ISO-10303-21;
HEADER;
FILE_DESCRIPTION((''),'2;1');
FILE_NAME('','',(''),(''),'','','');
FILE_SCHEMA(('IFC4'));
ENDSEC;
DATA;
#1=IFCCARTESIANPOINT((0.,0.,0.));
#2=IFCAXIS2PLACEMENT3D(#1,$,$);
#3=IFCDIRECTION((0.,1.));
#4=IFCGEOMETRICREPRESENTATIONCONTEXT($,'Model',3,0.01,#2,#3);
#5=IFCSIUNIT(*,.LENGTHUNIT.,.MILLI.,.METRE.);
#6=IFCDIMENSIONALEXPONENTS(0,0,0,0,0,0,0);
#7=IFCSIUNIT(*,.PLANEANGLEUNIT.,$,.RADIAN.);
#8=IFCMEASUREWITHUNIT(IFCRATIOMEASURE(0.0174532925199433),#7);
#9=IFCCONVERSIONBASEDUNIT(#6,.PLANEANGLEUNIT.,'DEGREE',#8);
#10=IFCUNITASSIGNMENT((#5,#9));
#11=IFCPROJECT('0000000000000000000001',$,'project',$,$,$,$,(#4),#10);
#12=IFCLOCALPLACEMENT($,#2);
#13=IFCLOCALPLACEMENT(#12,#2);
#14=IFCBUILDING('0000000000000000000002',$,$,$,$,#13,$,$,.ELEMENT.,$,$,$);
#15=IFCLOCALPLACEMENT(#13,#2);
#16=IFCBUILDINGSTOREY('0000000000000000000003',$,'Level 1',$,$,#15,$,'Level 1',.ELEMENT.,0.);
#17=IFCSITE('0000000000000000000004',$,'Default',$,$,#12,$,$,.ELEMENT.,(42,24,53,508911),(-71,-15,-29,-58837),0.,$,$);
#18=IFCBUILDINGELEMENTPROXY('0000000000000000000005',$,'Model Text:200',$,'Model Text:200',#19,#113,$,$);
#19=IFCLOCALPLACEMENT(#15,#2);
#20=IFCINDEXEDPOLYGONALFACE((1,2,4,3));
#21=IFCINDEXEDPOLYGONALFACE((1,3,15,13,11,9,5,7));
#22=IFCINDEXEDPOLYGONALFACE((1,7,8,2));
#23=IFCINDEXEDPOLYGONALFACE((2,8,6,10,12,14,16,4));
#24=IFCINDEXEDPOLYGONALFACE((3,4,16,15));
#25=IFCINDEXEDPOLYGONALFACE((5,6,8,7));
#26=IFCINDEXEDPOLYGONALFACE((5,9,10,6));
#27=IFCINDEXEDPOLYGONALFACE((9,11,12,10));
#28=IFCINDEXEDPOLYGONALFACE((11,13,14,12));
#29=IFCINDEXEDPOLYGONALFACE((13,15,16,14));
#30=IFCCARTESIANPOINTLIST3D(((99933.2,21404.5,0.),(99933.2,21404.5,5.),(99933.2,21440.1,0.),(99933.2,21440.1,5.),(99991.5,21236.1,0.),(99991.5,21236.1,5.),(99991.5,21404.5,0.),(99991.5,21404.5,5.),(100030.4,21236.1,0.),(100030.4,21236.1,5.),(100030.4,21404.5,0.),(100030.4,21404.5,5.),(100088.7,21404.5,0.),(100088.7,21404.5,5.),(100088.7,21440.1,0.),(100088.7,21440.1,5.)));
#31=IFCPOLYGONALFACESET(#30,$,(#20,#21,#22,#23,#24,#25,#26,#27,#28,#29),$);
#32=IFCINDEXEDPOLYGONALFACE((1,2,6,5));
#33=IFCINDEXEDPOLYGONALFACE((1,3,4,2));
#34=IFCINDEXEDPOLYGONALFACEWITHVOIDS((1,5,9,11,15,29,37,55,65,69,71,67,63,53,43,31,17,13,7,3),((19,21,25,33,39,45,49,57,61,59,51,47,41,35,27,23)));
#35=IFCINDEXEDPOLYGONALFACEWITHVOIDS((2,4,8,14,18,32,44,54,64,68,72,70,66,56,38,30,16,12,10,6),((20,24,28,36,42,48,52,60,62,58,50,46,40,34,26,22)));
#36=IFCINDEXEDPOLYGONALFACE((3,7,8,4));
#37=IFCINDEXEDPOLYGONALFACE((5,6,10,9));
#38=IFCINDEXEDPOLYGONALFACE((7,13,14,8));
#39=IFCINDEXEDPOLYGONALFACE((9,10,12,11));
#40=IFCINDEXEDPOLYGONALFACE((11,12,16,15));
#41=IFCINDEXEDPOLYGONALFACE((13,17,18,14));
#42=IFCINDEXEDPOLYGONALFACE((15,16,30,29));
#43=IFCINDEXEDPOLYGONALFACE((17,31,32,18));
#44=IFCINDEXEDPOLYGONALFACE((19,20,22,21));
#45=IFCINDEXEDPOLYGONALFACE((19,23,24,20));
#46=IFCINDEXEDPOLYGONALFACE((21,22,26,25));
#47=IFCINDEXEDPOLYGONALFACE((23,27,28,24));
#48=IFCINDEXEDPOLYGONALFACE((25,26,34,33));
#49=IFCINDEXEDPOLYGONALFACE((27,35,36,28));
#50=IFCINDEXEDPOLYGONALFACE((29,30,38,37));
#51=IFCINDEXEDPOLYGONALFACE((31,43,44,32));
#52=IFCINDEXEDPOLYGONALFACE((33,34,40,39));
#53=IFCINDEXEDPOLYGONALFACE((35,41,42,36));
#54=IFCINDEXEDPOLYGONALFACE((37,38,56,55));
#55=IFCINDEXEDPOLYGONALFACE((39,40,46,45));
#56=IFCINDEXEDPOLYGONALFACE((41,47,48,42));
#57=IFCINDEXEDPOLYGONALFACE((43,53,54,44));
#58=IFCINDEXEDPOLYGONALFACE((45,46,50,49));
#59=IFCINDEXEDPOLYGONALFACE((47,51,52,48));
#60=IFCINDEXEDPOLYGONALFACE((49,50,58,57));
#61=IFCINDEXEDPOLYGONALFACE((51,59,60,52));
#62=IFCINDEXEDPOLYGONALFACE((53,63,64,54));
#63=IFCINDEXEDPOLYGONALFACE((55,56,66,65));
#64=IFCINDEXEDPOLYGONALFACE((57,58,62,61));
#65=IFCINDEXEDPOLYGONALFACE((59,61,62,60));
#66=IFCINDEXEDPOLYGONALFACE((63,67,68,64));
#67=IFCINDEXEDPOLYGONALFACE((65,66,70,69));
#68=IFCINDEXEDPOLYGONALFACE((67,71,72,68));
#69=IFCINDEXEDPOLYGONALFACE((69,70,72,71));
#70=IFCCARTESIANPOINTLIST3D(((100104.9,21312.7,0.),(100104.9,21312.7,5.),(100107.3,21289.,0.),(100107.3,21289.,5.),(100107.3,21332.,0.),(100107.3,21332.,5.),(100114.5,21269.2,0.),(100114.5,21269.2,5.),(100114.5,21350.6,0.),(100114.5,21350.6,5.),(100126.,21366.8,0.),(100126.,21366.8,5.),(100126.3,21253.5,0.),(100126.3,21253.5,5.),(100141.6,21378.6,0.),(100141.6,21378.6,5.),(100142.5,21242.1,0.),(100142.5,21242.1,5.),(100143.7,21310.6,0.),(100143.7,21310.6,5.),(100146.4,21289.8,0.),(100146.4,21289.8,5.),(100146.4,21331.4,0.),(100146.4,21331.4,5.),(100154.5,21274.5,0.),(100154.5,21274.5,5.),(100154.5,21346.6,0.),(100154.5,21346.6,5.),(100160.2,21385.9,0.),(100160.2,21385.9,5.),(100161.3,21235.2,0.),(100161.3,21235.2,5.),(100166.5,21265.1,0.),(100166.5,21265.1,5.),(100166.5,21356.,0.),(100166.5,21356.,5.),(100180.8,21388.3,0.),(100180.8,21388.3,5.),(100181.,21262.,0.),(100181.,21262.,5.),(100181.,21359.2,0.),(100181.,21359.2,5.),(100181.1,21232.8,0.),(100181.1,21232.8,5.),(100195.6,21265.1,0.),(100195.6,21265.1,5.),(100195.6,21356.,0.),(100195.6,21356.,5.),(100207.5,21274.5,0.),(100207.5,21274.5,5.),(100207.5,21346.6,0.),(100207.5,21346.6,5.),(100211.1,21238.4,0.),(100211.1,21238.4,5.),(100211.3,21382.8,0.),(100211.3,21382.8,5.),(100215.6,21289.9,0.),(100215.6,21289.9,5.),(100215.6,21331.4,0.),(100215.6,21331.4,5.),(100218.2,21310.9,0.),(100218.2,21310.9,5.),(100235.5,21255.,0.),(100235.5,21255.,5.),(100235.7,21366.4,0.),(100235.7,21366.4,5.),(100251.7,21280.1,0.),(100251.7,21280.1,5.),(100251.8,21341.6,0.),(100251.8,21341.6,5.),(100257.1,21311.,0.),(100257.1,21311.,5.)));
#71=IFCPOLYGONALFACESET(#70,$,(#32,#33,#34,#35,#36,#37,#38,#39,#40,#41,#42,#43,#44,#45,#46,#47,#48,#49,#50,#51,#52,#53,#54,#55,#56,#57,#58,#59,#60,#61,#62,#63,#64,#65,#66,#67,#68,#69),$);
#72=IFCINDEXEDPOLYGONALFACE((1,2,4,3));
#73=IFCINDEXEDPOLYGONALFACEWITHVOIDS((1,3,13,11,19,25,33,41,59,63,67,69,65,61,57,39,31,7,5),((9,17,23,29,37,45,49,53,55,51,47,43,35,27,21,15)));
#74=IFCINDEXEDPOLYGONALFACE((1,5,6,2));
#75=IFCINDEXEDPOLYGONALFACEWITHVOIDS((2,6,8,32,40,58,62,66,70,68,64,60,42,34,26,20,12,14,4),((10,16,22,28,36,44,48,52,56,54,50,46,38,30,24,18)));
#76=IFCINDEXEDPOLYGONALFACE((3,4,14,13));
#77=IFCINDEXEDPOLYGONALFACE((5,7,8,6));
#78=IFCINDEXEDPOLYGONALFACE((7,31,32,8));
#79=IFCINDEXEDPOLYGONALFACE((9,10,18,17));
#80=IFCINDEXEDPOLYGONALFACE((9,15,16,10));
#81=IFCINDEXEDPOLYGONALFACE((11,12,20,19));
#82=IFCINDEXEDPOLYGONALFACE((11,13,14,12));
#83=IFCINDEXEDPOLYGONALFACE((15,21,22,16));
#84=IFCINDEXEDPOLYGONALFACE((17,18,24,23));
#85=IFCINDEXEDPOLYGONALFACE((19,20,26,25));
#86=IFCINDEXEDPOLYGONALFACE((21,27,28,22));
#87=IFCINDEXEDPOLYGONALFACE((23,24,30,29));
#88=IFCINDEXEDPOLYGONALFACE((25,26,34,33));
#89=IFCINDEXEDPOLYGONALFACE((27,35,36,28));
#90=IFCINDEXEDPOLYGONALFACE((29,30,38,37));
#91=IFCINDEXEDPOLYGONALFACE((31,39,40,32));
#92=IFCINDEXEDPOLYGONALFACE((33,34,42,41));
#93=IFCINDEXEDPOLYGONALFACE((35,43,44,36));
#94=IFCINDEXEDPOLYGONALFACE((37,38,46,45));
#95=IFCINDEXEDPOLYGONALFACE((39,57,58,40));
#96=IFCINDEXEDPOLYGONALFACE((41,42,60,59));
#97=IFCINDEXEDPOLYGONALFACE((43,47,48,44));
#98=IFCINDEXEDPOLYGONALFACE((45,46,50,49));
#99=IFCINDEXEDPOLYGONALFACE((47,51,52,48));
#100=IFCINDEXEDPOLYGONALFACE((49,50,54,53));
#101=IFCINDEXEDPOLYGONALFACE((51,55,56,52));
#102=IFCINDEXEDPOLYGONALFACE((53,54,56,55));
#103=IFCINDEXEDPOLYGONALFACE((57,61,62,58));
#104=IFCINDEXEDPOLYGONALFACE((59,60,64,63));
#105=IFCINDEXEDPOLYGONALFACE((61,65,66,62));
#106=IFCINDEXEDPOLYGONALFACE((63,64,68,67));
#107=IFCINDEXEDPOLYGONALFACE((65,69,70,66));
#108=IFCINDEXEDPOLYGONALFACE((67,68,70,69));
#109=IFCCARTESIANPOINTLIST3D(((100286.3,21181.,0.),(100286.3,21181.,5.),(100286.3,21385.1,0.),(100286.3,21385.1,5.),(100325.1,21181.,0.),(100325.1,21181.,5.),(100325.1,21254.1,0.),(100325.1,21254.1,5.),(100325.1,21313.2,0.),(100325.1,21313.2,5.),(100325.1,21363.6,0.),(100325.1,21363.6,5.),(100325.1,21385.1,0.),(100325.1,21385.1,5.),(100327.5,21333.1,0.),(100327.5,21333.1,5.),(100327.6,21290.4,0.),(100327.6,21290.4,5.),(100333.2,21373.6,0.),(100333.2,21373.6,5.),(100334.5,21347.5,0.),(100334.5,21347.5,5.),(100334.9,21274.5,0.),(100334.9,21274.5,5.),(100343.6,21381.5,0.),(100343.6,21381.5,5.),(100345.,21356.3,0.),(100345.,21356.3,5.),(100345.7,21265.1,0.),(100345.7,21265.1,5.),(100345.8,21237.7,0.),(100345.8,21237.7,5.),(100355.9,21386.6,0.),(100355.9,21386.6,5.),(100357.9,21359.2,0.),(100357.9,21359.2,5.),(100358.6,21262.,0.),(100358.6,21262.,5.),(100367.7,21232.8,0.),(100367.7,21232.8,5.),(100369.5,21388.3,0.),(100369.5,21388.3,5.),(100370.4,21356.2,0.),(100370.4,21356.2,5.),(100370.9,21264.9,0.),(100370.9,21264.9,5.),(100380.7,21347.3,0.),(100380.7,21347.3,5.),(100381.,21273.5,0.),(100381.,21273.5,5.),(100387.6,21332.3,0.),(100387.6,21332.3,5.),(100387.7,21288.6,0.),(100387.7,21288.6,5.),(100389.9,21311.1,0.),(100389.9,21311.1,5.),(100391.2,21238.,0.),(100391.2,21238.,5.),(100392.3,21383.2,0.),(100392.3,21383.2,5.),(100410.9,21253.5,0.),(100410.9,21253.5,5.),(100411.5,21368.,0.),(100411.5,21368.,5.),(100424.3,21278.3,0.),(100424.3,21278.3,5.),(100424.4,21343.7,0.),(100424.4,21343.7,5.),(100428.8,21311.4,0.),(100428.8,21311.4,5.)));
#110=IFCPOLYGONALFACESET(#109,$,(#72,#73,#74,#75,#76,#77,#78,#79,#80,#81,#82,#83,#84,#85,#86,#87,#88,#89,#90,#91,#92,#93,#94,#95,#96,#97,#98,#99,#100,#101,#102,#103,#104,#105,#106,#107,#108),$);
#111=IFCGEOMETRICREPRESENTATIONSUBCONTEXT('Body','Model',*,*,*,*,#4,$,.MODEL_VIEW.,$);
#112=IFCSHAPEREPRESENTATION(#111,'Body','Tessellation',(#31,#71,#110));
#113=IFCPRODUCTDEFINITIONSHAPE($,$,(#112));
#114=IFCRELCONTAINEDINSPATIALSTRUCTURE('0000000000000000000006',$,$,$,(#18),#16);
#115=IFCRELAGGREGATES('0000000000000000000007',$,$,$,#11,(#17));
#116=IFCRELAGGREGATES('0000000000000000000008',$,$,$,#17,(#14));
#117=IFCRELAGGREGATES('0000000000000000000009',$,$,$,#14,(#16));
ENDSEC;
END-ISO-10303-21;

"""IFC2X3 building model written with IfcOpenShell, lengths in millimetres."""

from ifc_helpers import new_model, entity, si_unit, converted_unit, direction, frame, origin, place, context, subcontext, project, spatial, polyline, outline, extrude, element, save


model = new_model("IFC2X3")

# Units and contexts
model_context = context("Model", 3, precision=0.01, world=origin(), true_north=direction((0.0, 1.0)))
body_context = subcontext(model_context, "Body", "Model", "MODEL_VIEW")
ifc_project = project(units=[si_unit("LENGTHUNIT", "METRE", prefix="MILLI"), converted_unit("PLANEANGLEUNIT", "DEGREE", entity("IfcRatioMeasure", 0.0174532925199433), si_unit("PLANEANGLEUNIT", "RADIAN"), dimensions=[0, 0, 0, 0, 0, 0, 0])], contexts=[model_context])

# Site, building, storey
site_placement = place(None, origin())
site = spatial("IfcSite", under=ifc_project, at=site_placement, Name="Default", CompositionType="ELEMENT", RefLatitude=(42, 24, 53, 508911), RefLongitude=(-71, -15, -29, -58837), RefElevation=0.0)
building_placement = place(site_placement, origin())
building = spatial("IfcBuilding", under=site, at=building_placement, CompositionType="ELEMENT")
storey_placement = place(building_placement, origin())
storey = spatial("IfcBuildingStorey", under=building, at=storey_placement, Name="Level 1", LongName="Level 1", CompositionType="ELEMENT", Elevation=0.0)

# Building element proxy
proxy_1_placement = place(storey_placement, origin())
element("IfcBuildingElementProxy", 1, at=proxy_1_placement, inside=storey, Name="Model Text:200", ObjectType="Model Text:200", context=body_context, shape_type="SweptSolid", body=[
    extrude(outline(polyline([(-19.4, -135.2), (19.4, -135.2), (19.4, 33.2), (77.7, 33.2), (77.7, 68.8), (-77.7, 68.8), (-77.7, 33.2), (-19.4, 33.2), (-19.4, -135.2)])), frame((100010.9, 21371.3, 0.0)), (0.0, 0.0, 1.0), 5.0),
    extrude(outline(polyline([(-8.8, -65.7), (15.1, -65.7), (35.5, -60.5), (52.3, -50.4), (65.3, -35.4), (74.1, -17.3), (78.4, 2.1), (75.9, 32.5), (61.8, 58.5), (38.4, 77.1), (8.3, 85.6), (-22.7, 83.3), (-49.0, 69.9), (-67.8, 47.3), (-76.3, 17.5), (-76.0, -3.3), (-70.7, -22.5), (-60.5, -39.2), (-45.5, -52.3), (-27.7, -61.4), (-8.8, -65.7)]), holes=[polyline([(-2.7, -27.2), (-23.1, -22.5), (-37.5, -12.9), (-45.7, 0.0), (-47.3, 14.8), (-42.7, 28.9), (-32.2, 39.9), (-16.3, 46.3), (4.5, 46.9), (25.1, 42.1), (39.6, 32.6), (47.7, 19.7), (49.4, 5.0), (44.8, -9.2), (34.2, -20.2), (18.2, -26.7), (-2.7, -27.2)])]), frame((100171.1, 21310.6, 0.0), z_axis=(0.0, 0.0, 1.0), x_axis=(0.100608, -0.994926, 0.0)), (0.0, 0.0, 1.0), 5.0),
    extrude(outline(polyline([(-73.1, -75.4), (130.9, -75.4), (130.9, -36.6), (57.8, -36.6), (74.3, -15.9), (79.1, 6.0), (73.9, 29.5), (58.4, 49.2), (33.6, 62.6), (0.5, 67.1), (-31.8, 62.8), (-56.1, 49.8), (-71.3, 30.7), (-76.4, 7.8), (-74.7, -5.8), (-69.6, -18.1), (-61.7, -28.5), (-51.7, -36.6), (-73.1, -36.6), (-73.1, -75.4)]), holes=[polyline([(-1.2, -36.6), (-21.2, -34.2), (-35.6, -27.2), (-44.3, -16.7), (-47.2, -3.8), (-44.3, 8.7), (-35.4, 19.0), (-20.4, 25.9), (0.8, 28.2), (23.3, 26.0), (38.5, 19.3), (47.1, 9.2), (49.9, -3.1), (46.8, -16.0), (37.4, -26.8), (21.5, -34.1), (-1.2, -36.6)])]), frame((100361.7, 21311.9, 0.0), z_axis=(0.0, 0.0, 1.0), x_axis=(0.0, -1.0, 0.0)), (0.0, 0.0, 1.0), 5.0),
])

save(model, "model.ifc")
